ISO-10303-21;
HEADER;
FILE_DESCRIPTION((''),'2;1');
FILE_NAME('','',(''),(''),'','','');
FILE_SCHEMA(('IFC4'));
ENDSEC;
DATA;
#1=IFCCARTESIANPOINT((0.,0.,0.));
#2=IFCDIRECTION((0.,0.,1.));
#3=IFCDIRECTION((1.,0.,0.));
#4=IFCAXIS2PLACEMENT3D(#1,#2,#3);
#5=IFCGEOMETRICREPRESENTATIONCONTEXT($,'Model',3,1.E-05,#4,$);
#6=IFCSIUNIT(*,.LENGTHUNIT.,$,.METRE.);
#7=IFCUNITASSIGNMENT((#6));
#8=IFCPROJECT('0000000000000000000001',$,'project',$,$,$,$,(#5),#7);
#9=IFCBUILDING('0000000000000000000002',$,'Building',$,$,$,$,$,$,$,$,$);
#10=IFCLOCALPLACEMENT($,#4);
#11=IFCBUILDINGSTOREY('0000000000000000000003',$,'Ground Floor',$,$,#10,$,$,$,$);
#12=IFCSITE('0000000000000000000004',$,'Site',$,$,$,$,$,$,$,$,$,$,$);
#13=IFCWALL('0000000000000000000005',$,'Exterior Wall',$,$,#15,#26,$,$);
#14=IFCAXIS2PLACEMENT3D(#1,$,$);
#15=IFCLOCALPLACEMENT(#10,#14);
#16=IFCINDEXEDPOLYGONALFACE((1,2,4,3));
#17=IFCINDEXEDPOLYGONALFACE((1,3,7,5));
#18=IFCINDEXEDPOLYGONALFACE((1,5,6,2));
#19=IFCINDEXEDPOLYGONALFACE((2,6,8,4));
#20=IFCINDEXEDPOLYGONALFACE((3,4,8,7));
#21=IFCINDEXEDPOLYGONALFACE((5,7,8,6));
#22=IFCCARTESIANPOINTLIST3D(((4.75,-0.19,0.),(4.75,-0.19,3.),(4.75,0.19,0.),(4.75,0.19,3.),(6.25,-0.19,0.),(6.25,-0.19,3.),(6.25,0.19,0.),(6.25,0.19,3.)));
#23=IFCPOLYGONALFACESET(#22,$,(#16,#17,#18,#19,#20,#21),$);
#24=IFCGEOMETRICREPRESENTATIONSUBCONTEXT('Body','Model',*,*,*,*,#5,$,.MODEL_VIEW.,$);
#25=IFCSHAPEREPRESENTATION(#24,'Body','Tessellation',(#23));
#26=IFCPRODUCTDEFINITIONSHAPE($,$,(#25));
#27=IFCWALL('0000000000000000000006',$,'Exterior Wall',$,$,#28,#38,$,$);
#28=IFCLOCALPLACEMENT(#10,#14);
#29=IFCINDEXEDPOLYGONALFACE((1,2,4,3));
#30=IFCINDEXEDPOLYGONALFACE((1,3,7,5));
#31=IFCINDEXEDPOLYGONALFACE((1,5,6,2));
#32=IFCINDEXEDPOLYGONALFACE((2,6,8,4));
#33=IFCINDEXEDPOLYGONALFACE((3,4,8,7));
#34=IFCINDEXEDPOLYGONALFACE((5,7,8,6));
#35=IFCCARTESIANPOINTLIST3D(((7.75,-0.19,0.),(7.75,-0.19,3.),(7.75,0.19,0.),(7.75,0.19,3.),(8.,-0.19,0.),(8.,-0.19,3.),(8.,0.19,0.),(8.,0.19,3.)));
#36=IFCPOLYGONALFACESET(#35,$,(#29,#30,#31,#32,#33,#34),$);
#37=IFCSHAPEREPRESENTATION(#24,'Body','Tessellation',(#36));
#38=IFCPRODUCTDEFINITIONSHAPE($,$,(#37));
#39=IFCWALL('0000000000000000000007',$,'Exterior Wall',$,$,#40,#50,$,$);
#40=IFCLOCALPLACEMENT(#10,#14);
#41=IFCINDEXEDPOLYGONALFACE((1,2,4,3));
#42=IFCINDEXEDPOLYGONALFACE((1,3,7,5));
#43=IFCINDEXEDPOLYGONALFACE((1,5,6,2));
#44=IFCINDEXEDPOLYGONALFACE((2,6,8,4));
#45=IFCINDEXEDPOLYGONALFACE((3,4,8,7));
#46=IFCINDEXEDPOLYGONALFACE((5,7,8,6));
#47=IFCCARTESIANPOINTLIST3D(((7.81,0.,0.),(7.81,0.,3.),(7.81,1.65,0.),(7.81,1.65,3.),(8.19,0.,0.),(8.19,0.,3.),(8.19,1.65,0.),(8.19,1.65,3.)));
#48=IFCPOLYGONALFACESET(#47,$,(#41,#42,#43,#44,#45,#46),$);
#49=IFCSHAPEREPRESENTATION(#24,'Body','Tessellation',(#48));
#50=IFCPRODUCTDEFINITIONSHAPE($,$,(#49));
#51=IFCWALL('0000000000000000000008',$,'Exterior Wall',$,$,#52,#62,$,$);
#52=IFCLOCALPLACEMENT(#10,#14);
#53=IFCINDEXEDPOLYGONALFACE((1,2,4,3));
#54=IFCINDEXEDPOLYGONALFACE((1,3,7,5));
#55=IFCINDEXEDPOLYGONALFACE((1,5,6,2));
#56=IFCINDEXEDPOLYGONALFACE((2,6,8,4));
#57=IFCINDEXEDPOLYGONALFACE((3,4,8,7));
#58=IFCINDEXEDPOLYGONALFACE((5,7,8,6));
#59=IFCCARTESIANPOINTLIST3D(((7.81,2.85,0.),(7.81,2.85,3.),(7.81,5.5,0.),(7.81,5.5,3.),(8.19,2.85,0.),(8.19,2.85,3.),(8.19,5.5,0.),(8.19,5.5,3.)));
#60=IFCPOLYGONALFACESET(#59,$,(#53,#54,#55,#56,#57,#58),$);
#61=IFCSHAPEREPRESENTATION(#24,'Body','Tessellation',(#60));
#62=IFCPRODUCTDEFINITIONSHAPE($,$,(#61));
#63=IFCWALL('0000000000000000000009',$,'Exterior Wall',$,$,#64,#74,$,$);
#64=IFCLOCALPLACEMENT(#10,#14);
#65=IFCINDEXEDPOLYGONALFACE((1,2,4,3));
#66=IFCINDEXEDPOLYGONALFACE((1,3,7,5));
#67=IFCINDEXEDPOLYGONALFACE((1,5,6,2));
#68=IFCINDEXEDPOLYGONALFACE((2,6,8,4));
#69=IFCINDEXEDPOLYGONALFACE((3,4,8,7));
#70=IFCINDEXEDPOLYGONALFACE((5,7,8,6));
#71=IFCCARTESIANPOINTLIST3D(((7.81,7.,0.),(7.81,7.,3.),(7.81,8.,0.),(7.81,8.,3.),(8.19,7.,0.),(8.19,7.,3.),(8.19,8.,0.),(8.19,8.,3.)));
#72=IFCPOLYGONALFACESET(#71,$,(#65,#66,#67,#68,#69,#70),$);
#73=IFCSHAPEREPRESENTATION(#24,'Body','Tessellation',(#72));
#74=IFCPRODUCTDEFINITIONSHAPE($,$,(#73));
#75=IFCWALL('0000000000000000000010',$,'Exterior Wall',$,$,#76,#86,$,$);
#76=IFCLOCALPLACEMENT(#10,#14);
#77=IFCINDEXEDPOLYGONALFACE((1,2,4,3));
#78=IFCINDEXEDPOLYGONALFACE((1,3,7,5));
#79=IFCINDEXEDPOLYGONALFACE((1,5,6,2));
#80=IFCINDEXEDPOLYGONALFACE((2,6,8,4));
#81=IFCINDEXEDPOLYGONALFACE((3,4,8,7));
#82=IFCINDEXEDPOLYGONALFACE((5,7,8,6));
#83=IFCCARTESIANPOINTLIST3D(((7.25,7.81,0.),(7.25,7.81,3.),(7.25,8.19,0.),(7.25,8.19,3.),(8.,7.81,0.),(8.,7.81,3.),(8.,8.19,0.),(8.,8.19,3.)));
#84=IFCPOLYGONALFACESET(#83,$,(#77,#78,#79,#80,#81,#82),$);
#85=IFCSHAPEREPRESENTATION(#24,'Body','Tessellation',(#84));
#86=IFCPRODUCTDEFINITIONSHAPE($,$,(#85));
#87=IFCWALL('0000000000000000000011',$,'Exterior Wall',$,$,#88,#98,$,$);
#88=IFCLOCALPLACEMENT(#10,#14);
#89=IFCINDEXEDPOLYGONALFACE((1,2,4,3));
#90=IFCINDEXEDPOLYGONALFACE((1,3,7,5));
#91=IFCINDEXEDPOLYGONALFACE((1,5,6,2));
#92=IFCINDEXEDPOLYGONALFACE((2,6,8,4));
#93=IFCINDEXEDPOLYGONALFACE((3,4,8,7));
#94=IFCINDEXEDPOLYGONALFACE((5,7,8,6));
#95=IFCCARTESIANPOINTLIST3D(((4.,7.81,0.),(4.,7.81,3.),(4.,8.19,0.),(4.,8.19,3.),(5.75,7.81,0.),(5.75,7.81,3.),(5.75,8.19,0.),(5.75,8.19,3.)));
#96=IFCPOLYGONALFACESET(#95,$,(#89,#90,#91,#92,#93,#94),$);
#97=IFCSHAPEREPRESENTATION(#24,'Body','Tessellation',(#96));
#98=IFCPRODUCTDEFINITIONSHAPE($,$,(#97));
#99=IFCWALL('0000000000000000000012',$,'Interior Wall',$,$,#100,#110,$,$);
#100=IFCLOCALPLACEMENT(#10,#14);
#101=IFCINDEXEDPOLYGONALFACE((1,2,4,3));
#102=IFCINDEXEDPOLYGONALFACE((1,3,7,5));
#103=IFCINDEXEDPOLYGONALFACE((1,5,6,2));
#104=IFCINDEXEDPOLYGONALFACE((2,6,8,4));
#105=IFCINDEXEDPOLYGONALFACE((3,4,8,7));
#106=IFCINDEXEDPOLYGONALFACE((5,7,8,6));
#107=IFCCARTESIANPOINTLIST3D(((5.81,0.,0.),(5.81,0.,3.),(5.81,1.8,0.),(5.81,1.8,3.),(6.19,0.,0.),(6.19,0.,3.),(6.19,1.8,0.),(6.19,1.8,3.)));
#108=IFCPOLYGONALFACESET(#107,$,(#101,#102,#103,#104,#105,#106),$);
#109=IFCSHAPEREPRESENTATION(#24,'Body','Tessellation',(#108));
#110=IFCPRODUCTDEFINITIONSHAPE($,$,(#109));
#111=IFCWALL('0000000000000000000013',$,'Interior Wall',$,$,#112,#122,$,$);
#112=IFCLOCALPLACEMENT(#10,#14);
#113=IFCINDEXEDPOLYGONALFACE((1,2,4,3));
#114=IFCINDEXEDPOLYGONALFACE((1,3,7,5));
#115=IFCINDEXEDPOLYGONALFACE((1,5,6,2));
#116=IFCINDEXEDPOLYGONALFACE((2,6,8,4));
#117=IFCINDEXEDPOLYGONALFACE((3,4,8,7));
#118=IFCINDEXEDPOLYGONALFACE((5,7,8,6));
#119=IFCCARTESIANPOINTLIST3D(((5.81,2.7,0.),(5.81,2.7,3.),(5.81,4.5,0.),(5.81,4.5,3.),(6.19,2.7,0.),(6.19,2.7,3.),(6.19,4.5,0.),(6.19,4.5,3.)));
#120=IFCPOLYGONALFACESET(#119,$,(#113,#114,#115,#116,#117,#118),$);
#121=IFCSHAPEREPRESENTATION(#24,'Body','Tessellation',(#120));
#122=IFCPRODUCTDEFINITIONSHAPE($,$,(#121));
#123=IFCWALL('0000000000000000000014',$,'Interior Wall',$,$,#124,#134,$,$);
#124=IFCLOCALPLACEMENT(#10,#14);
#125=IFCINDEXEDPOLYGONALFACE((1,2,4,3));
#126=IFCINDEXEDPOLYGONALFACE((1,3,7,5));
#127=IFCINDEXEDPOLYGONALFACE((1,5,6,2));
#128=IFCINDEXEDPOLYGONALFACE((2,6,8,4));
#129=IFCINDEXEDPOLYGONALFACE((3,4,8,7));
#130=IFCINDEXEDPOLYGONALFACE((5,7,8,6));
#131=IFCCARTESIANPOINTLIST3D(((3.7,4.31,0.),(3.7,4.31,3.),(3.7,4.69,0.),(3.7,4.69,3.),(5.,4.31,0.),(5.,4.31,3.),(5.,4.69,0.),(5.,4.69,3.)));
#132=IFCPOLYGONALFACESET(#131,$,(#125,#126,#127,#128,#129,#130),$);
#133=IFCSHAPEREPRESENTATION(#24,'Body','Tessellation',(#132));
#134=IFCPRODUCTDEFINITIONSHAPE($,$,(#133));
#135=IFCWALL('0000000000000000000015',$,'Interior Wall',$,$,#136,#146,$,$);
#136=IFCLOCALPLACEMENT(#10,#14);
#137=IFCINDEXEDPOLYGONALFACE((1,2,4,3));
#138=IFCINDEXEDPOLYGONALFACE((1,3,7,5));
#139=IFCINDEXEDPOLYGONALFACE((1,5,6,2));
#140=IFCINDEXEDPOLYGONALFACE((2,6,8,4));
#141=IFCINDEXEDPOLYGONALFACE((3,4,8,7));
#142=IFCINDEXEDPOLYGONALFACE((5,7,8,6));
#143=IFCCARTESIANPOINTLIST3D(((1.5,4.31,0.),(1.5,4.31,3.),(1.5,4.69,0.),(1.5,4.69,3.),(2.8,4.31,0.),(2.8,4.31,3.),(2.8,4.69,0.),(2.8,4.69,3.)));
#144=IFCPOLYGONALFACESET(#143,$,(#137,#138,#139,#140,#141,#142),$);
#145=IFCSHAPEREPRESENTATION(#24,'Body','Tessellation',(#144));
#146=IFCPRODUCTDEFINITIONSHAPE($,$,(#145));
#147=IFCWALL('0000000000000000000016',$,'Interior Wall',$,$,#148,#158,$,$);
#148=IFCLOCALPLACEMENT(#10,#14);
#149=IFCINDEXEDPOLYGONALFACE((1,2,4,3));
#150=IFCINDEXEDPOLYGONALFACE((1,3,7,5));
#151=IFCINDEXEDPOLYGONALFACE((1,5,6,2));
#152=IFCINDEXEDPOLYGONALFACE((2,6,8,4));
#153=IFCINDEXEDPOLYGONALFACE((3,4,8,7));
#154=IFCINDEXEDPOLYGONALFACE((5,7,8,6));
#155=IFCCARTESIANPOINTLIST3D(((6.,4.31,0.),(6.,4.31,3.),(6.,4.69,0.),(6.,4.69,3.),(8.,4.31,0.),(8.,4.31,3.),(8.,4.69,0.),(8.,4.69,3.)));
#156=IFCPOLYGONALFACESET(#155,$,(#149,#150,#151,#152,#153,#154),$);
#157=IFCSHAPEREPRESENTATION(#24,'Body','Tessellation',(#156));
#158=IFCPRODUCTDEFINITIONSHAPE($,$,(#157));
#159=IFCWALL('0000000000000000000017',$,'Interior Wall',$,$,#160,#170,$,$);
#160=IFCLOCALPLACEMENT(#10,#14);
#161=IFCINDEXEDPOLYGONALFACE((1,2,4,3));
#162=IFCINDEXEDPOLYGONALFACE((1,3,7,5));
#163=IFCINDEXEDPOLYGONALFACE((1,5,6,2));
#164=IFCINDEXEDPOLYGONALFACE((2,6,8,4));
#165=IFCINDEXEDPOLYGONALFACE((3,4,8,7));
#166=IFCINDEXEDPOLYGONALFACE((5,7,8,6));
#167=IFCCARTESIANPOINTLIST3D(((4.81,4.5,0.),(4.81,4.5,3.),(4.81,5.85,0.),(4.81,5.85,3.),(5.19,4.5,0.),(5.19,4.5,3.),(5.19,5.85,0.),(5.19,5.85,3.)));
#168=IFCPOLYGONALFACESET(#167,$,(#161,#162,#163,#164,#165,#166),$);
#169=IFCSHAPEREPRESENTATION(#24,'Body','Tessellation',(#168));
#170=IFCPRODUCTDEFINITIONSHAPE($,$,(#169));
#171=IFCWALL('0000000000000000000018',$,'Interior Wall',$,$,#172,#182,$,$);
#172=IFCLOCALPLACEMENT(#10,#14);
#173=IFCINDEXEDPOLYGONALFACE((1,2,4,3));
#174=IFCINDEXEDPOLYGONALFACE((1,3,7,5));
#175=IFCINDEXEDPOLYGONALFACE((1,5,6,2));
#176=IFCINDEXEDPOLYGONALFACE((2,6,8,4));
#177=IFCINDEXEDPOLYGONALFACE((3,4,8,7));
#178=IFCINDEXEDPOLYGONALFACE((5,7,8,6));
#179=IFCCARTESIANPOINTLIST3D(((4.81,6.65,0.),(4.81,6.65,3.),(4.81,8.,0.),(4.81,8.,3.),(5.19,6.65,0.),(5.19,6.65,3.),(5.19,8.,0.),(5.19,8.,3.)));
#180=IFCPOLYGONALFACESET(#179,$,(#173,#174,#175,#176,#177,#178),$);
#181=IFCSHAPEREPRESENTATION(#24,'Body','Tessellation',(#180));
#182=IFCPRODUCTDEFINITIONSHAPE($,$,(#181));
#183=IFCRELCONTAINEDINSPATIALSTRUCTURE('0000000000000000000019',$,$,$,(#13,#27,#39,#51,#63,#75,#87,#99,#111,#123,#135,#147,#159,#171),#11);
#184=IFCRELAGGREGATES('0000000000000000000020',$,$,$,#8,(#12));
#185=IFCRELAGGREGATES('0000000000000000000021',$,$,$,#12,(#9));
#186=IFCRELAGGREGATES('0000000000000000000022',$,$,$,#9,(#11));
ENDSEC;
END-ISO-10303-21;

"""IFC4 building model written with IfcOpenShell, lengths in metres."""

from ifc_helpers import new_model, si_unit, frame, origin_with_axes, place, context, subcontext, project, spatial, indexed_curve, outline, extrude, element, save


model = new_model("IFC4")

# Units and contexts
model_context = context("Model", 3, precision=1e-05, world=origin_with_axes())
body_context = subcontext(model_context, "Body", "Model", "MODEL_VIEW")
ifc_project = project(units=[si_unit("LENGTHUNIT", "METRE")], contexts=[model_context])

# Site, building, storey
site = spatial("IfcSite", under=ifc_project, Name="Site")
building = spatial("IfcBuilding", under=site, Name="Building")
storey_placement = place(None, origin_with_axes())
storey = spatial("IfcBuildingStorey", under=building, at=storey_placement, Name="Ground Floor")

# Walls
wall_1_placement = place(storey_placement, frame((4.75, 0.0, 0.0), z_axis=(0.0, 0.0, 1.0), x_axis=(1.0, 0.0, 0.0)))
element("IfcWall", 1, at=wall_1_placement, inside=storey, Name="Exterior Wall", context=body_context, shape_type="SweptSolid", body=[
    extrude(outline(indexed_curve([(0.0, 0.0), (0.0, 0.38), (1.5, 0.38), (1.5, 0.0), (0.0, 0.0)], self_intersect=False)), frame((0.0, -0.19, 0.0), z_axis=(0.0, 0.0, 1.0), x_axis=(1.0, 0.0, 0.0)), (0.0, 0.0, 1.0), 3.0),
])
wall_2_placement = place(storey_placement, frame((7.75, 0.0, 0.0), z_axis=(0.0, 0.0, 1.0), x_axis=(1.0, 0.0, 0.0)))
element("IfcWall", 2, at=wall_2_placement, inside=storey, Name="Exterior Wall", context=body_context, shape_type="SweptSolid", body=[
    extrude(outline(indexed_curve([(0.0, 0.0), (0.0, 0.38), (0.25, 0.38), (0.25, 0.0), (0.0, 0.0)], self_intersect=False)), frame((0.0, -0.19, 0.0), z_axis=(0.0, 0.0, 1.0), x_axis=(1.0, 0.0, 0.0)), (0.0, 0.0, 1.0), 3.0),
])
wall_3_placement = place(storey_placement, frame((8.0, 0.0, 0.0), z_axis=(0.0, 0.0, 1.0), x_axis=(0.0, 1.0, 0.0)))
element("IfcWall", 3, at=wall_3_placement, inside=storey, Name="Exterior Wall", context=body_context, shape_type="SweptSolid", body=[
    extrude(outline(indexed_curve([(0.0, 0.0), (0.0, 0.38), (1.65, 0.38), (1.65, 0.0), (0.0, 0.0)], self_intersect=False)), frame((0.0, -0.19, 0.0), z_axis=(0.0, 0.0, 1.0), x_axis=(1.0, 0.0, 0.0)), (0.0, 0.0, 1.0), 3.0),
])
wall_4_placement = place(storey_placement, frame((8.0, 2.85, 0.0), z_axis=(0.0, 0.0, 1.0), x_axis=(0.0, 1.0, 0.0)))
element("IfcWall", 4, at=wall_4_placement, inside=storey, Name="Exterior Wall", context=body_context, shape_type="SweptSolid", body=[
    extrude(outline(indexed_curve([(0.0, 0.0), (0.0, 0.38), (2.65, 0.38), (2.65, 0.0), (0.0, 0.0)], self_intersect=False)), frame((0.0, -0.19, 0.0), z_axis=(0.0, 0.0, 1.0), x_axis=(1.0, 0.0, 0.0)), (0.0, 0.0, 1.0), 3.0),
])
wall_5_placement = place(storey_placement, frame((8.0, 7.0, 0.0), z_axis=(0.0, 0.0, 1.0), x_axis=(0.0, 1.0, 0.0)))
element("IfcWall", 5, at=wall_5_placement, inside=storey, Name="Exterior Wall", context=body_context, shape_type="SweptSolid", body=[
    extrude(outline(indexed_curve([(0.0, 0.0), (0.0, 0.38), (1.0, 0.38), (1.0, 0.0), (0.0, 0.0)], self_intersect=False)), frame((0.0, -0.19, 0.0), z_axis=(0.0, 0.0, 1.0), x_axis=(1.0, 0.0, 0.0)), (0.0, 0.0, 1.0), 3.0),
])
wall_6_placement = place(storey_placement, frame((8.0, 8.0, 0.0), z_axis=(0.0, 0.0, 1.0), x_axis=(-1.0, 0.0, 0.0)))
element("IfcWall", 6, at=wall_6_placement, inside=storey, Name="Exterior Wall", context=body_context, shape_type="SweptSolid", body=[
    extrude(outline(indexed_curve([(0.0, 0.0), (0.0, 0.38), (0.75, 0.38), (0.75, 0.0), (0.0, 0.0)], self_intersect=False)), frame((0.0, -0.19, 0.0), z_axis=(0.0, 0.0, 1.0), x_axis=(1.0, 0.0, 0.0)), (0.0, 0.0, 1.0), 3.0),
])
wall_7_placement = place(storey_placement, frame((5.75, 8.0, 0.0), z_axis=(0.0, 0.0, 1.0), x_axis=(-1.0, 0.0, 0.0)))
element("IfcWall", 7, at=wall_7_placement, inside=storey, Name="Exterior Wall", context=body_context, shape_type="SweptSolid", body=[
    extrude(outline(indexed_curve([(0.0, 0.0), (0.0, 0.38), (1.75, 0.38), (1.75, 0.0), (0.0, 0.0)], self_intersect=False)), frame((0.0, -0.19, 0.0), z_axis=(0.0, 0.0, 1.0), x_axis=(1.0, 0.0, 0.0)), (0.0, 0.0, 1.0), 3.0),
])
wall_8_placement = place(storey_placement, frame((6.0, 0.0, 0.0), z_axis=(0.0, 0.0, 1.0), x_axis=(0.0, 1.0, 0.0)))
element("IfcWall", 8, at=wall_8_placement, inside=storey, Name="Interior Wall", context=body_context, shape_type="SweptSolid", body=[
    extrude(outline(indexed_curve([(0.0, 0.0), (0.0, 0.38), (1.8, 0.38), (1.8, 0.0), (0.0, 0.0)], self_intersect=False)), frame((0.0, -0.19, 0.0), z_axis=(0.0, 0.0, 1.0), x_axis=(1.0, 0.0, 0.0)), (0.0, 0.0, 1.0), 3.0),
])
wall_9_placement = place(storey_placement, frame((6.0, 2.7, 0.0), z_axis=(0.0, 0.0, 1.0), x_axis=(0.0, 1.0, 0.0)))
element("IfcWall", 9, at=wall_9_placement, inside=storey, Name="Interior Wall", context=body_context, shape_type="SweptSolid", body=[
    extrude(outline(indexed_curve([(0.0, 0.0), (0.0, 0.38), (1.8, 0.38), (1.8, 0.0), (0.0, 0.0)], self_intersect=False)), frame((0.0, -0.19, 0.0), z_axis=(0.0, 0.0, 1.0), x_axis=(1.0, 0.0, 0.0)), (0.0, 0.0, 1.0), 3.0),
])
for number, where, z_axis, x_axis, name in (
    (10, (5.0, 4.5, 0.0), (0.0, 0.0, 1.0), (-1.0, 0.0, 0.0), "Interior Wall"),
    (11, (2.8, 4.5, 0.0), (0.0, 0.0, 1.0), (-1.0, 0.0, 0.0), "Interior Wall"),
):
    element("IfcWall", number, at=place(storey_placement, frame(where, z_axis=z_axis, x_axis=x_axis)), inside=storey, Name=name, context=body_context, shape_type="SweptSolid", body=[
        extrude(outline(indexed_curve([(0.0, 0.0), (0.0, 0.38), (1.3, 0.38), (1.3, 0.0), (0.0, 0.0)], self_intersect=False)), frame((0.0, -0.19, 0.0), z_axis=(0.0, 0.0, 1.0), x_axis=(1.0, 0.0, 0.0)), (0.0, 0.0, 1.0), 3.0),
    ])
wall_10_placement = place(storey_placement, frame((8.0, 4.5, 0.0), z_axis=(0.0, 0.0, 1.0), x_axis=(-1.0, 0.0, 0.0)))
element("IfcWall", 12, at=wall_10_placement, inside=storey, Name="Interior Wall", context=body_context, shape_type="SweptSolid", body=[
    extrude(outline(indexed_curve([(0.0, 0.0), (0.0, 0.38), (2.0, 0.38), (2.0, 0.0), (0.0, 0.0)], self_intersect=False)), frame((0.0, -0.19, 0.0), z_axis=(0.0, 0.0, 1.0), x_axis=(1.0, 0.0, 0.0)), (0.0, 0.0, 1.0), 3.0),
])
for number, where, z_axis, x_axis, name in (
    (13, (5.0, 4.5, 0.0), (0.0, 0.0, 1.0), (0.0, 1.0, 0.0), "Interior Wall"),
    (14, (5.0, 6.65, 0.0), (0.0, 0.0, 1.0), (0.0, 1.0, 0.0), "Interior Wall"),
):
    element("IfcWall", number, at=place(storey_placement, frame(where, z_axis=z_axis, x_axis=x_axis)), inside=storey, Name=name, context=body_context, shape_type="SweptSolid", body=[
        extrude(outline(indexed_curve([(0.0, 0.0), (0.0, 0.38), (1.35, 0.38), (1.35, 0.0), (0.0, 0.0)], self_intersect=False)), frame((0.0, -0.19, 0.0), z_axis=(0.0, 0.0, 1.0), x_axis=(1.0, 0.0, 0.0)), (0.0, 0.0, 1.0), 3.0),
    ])

save(model, "model.ifc")
